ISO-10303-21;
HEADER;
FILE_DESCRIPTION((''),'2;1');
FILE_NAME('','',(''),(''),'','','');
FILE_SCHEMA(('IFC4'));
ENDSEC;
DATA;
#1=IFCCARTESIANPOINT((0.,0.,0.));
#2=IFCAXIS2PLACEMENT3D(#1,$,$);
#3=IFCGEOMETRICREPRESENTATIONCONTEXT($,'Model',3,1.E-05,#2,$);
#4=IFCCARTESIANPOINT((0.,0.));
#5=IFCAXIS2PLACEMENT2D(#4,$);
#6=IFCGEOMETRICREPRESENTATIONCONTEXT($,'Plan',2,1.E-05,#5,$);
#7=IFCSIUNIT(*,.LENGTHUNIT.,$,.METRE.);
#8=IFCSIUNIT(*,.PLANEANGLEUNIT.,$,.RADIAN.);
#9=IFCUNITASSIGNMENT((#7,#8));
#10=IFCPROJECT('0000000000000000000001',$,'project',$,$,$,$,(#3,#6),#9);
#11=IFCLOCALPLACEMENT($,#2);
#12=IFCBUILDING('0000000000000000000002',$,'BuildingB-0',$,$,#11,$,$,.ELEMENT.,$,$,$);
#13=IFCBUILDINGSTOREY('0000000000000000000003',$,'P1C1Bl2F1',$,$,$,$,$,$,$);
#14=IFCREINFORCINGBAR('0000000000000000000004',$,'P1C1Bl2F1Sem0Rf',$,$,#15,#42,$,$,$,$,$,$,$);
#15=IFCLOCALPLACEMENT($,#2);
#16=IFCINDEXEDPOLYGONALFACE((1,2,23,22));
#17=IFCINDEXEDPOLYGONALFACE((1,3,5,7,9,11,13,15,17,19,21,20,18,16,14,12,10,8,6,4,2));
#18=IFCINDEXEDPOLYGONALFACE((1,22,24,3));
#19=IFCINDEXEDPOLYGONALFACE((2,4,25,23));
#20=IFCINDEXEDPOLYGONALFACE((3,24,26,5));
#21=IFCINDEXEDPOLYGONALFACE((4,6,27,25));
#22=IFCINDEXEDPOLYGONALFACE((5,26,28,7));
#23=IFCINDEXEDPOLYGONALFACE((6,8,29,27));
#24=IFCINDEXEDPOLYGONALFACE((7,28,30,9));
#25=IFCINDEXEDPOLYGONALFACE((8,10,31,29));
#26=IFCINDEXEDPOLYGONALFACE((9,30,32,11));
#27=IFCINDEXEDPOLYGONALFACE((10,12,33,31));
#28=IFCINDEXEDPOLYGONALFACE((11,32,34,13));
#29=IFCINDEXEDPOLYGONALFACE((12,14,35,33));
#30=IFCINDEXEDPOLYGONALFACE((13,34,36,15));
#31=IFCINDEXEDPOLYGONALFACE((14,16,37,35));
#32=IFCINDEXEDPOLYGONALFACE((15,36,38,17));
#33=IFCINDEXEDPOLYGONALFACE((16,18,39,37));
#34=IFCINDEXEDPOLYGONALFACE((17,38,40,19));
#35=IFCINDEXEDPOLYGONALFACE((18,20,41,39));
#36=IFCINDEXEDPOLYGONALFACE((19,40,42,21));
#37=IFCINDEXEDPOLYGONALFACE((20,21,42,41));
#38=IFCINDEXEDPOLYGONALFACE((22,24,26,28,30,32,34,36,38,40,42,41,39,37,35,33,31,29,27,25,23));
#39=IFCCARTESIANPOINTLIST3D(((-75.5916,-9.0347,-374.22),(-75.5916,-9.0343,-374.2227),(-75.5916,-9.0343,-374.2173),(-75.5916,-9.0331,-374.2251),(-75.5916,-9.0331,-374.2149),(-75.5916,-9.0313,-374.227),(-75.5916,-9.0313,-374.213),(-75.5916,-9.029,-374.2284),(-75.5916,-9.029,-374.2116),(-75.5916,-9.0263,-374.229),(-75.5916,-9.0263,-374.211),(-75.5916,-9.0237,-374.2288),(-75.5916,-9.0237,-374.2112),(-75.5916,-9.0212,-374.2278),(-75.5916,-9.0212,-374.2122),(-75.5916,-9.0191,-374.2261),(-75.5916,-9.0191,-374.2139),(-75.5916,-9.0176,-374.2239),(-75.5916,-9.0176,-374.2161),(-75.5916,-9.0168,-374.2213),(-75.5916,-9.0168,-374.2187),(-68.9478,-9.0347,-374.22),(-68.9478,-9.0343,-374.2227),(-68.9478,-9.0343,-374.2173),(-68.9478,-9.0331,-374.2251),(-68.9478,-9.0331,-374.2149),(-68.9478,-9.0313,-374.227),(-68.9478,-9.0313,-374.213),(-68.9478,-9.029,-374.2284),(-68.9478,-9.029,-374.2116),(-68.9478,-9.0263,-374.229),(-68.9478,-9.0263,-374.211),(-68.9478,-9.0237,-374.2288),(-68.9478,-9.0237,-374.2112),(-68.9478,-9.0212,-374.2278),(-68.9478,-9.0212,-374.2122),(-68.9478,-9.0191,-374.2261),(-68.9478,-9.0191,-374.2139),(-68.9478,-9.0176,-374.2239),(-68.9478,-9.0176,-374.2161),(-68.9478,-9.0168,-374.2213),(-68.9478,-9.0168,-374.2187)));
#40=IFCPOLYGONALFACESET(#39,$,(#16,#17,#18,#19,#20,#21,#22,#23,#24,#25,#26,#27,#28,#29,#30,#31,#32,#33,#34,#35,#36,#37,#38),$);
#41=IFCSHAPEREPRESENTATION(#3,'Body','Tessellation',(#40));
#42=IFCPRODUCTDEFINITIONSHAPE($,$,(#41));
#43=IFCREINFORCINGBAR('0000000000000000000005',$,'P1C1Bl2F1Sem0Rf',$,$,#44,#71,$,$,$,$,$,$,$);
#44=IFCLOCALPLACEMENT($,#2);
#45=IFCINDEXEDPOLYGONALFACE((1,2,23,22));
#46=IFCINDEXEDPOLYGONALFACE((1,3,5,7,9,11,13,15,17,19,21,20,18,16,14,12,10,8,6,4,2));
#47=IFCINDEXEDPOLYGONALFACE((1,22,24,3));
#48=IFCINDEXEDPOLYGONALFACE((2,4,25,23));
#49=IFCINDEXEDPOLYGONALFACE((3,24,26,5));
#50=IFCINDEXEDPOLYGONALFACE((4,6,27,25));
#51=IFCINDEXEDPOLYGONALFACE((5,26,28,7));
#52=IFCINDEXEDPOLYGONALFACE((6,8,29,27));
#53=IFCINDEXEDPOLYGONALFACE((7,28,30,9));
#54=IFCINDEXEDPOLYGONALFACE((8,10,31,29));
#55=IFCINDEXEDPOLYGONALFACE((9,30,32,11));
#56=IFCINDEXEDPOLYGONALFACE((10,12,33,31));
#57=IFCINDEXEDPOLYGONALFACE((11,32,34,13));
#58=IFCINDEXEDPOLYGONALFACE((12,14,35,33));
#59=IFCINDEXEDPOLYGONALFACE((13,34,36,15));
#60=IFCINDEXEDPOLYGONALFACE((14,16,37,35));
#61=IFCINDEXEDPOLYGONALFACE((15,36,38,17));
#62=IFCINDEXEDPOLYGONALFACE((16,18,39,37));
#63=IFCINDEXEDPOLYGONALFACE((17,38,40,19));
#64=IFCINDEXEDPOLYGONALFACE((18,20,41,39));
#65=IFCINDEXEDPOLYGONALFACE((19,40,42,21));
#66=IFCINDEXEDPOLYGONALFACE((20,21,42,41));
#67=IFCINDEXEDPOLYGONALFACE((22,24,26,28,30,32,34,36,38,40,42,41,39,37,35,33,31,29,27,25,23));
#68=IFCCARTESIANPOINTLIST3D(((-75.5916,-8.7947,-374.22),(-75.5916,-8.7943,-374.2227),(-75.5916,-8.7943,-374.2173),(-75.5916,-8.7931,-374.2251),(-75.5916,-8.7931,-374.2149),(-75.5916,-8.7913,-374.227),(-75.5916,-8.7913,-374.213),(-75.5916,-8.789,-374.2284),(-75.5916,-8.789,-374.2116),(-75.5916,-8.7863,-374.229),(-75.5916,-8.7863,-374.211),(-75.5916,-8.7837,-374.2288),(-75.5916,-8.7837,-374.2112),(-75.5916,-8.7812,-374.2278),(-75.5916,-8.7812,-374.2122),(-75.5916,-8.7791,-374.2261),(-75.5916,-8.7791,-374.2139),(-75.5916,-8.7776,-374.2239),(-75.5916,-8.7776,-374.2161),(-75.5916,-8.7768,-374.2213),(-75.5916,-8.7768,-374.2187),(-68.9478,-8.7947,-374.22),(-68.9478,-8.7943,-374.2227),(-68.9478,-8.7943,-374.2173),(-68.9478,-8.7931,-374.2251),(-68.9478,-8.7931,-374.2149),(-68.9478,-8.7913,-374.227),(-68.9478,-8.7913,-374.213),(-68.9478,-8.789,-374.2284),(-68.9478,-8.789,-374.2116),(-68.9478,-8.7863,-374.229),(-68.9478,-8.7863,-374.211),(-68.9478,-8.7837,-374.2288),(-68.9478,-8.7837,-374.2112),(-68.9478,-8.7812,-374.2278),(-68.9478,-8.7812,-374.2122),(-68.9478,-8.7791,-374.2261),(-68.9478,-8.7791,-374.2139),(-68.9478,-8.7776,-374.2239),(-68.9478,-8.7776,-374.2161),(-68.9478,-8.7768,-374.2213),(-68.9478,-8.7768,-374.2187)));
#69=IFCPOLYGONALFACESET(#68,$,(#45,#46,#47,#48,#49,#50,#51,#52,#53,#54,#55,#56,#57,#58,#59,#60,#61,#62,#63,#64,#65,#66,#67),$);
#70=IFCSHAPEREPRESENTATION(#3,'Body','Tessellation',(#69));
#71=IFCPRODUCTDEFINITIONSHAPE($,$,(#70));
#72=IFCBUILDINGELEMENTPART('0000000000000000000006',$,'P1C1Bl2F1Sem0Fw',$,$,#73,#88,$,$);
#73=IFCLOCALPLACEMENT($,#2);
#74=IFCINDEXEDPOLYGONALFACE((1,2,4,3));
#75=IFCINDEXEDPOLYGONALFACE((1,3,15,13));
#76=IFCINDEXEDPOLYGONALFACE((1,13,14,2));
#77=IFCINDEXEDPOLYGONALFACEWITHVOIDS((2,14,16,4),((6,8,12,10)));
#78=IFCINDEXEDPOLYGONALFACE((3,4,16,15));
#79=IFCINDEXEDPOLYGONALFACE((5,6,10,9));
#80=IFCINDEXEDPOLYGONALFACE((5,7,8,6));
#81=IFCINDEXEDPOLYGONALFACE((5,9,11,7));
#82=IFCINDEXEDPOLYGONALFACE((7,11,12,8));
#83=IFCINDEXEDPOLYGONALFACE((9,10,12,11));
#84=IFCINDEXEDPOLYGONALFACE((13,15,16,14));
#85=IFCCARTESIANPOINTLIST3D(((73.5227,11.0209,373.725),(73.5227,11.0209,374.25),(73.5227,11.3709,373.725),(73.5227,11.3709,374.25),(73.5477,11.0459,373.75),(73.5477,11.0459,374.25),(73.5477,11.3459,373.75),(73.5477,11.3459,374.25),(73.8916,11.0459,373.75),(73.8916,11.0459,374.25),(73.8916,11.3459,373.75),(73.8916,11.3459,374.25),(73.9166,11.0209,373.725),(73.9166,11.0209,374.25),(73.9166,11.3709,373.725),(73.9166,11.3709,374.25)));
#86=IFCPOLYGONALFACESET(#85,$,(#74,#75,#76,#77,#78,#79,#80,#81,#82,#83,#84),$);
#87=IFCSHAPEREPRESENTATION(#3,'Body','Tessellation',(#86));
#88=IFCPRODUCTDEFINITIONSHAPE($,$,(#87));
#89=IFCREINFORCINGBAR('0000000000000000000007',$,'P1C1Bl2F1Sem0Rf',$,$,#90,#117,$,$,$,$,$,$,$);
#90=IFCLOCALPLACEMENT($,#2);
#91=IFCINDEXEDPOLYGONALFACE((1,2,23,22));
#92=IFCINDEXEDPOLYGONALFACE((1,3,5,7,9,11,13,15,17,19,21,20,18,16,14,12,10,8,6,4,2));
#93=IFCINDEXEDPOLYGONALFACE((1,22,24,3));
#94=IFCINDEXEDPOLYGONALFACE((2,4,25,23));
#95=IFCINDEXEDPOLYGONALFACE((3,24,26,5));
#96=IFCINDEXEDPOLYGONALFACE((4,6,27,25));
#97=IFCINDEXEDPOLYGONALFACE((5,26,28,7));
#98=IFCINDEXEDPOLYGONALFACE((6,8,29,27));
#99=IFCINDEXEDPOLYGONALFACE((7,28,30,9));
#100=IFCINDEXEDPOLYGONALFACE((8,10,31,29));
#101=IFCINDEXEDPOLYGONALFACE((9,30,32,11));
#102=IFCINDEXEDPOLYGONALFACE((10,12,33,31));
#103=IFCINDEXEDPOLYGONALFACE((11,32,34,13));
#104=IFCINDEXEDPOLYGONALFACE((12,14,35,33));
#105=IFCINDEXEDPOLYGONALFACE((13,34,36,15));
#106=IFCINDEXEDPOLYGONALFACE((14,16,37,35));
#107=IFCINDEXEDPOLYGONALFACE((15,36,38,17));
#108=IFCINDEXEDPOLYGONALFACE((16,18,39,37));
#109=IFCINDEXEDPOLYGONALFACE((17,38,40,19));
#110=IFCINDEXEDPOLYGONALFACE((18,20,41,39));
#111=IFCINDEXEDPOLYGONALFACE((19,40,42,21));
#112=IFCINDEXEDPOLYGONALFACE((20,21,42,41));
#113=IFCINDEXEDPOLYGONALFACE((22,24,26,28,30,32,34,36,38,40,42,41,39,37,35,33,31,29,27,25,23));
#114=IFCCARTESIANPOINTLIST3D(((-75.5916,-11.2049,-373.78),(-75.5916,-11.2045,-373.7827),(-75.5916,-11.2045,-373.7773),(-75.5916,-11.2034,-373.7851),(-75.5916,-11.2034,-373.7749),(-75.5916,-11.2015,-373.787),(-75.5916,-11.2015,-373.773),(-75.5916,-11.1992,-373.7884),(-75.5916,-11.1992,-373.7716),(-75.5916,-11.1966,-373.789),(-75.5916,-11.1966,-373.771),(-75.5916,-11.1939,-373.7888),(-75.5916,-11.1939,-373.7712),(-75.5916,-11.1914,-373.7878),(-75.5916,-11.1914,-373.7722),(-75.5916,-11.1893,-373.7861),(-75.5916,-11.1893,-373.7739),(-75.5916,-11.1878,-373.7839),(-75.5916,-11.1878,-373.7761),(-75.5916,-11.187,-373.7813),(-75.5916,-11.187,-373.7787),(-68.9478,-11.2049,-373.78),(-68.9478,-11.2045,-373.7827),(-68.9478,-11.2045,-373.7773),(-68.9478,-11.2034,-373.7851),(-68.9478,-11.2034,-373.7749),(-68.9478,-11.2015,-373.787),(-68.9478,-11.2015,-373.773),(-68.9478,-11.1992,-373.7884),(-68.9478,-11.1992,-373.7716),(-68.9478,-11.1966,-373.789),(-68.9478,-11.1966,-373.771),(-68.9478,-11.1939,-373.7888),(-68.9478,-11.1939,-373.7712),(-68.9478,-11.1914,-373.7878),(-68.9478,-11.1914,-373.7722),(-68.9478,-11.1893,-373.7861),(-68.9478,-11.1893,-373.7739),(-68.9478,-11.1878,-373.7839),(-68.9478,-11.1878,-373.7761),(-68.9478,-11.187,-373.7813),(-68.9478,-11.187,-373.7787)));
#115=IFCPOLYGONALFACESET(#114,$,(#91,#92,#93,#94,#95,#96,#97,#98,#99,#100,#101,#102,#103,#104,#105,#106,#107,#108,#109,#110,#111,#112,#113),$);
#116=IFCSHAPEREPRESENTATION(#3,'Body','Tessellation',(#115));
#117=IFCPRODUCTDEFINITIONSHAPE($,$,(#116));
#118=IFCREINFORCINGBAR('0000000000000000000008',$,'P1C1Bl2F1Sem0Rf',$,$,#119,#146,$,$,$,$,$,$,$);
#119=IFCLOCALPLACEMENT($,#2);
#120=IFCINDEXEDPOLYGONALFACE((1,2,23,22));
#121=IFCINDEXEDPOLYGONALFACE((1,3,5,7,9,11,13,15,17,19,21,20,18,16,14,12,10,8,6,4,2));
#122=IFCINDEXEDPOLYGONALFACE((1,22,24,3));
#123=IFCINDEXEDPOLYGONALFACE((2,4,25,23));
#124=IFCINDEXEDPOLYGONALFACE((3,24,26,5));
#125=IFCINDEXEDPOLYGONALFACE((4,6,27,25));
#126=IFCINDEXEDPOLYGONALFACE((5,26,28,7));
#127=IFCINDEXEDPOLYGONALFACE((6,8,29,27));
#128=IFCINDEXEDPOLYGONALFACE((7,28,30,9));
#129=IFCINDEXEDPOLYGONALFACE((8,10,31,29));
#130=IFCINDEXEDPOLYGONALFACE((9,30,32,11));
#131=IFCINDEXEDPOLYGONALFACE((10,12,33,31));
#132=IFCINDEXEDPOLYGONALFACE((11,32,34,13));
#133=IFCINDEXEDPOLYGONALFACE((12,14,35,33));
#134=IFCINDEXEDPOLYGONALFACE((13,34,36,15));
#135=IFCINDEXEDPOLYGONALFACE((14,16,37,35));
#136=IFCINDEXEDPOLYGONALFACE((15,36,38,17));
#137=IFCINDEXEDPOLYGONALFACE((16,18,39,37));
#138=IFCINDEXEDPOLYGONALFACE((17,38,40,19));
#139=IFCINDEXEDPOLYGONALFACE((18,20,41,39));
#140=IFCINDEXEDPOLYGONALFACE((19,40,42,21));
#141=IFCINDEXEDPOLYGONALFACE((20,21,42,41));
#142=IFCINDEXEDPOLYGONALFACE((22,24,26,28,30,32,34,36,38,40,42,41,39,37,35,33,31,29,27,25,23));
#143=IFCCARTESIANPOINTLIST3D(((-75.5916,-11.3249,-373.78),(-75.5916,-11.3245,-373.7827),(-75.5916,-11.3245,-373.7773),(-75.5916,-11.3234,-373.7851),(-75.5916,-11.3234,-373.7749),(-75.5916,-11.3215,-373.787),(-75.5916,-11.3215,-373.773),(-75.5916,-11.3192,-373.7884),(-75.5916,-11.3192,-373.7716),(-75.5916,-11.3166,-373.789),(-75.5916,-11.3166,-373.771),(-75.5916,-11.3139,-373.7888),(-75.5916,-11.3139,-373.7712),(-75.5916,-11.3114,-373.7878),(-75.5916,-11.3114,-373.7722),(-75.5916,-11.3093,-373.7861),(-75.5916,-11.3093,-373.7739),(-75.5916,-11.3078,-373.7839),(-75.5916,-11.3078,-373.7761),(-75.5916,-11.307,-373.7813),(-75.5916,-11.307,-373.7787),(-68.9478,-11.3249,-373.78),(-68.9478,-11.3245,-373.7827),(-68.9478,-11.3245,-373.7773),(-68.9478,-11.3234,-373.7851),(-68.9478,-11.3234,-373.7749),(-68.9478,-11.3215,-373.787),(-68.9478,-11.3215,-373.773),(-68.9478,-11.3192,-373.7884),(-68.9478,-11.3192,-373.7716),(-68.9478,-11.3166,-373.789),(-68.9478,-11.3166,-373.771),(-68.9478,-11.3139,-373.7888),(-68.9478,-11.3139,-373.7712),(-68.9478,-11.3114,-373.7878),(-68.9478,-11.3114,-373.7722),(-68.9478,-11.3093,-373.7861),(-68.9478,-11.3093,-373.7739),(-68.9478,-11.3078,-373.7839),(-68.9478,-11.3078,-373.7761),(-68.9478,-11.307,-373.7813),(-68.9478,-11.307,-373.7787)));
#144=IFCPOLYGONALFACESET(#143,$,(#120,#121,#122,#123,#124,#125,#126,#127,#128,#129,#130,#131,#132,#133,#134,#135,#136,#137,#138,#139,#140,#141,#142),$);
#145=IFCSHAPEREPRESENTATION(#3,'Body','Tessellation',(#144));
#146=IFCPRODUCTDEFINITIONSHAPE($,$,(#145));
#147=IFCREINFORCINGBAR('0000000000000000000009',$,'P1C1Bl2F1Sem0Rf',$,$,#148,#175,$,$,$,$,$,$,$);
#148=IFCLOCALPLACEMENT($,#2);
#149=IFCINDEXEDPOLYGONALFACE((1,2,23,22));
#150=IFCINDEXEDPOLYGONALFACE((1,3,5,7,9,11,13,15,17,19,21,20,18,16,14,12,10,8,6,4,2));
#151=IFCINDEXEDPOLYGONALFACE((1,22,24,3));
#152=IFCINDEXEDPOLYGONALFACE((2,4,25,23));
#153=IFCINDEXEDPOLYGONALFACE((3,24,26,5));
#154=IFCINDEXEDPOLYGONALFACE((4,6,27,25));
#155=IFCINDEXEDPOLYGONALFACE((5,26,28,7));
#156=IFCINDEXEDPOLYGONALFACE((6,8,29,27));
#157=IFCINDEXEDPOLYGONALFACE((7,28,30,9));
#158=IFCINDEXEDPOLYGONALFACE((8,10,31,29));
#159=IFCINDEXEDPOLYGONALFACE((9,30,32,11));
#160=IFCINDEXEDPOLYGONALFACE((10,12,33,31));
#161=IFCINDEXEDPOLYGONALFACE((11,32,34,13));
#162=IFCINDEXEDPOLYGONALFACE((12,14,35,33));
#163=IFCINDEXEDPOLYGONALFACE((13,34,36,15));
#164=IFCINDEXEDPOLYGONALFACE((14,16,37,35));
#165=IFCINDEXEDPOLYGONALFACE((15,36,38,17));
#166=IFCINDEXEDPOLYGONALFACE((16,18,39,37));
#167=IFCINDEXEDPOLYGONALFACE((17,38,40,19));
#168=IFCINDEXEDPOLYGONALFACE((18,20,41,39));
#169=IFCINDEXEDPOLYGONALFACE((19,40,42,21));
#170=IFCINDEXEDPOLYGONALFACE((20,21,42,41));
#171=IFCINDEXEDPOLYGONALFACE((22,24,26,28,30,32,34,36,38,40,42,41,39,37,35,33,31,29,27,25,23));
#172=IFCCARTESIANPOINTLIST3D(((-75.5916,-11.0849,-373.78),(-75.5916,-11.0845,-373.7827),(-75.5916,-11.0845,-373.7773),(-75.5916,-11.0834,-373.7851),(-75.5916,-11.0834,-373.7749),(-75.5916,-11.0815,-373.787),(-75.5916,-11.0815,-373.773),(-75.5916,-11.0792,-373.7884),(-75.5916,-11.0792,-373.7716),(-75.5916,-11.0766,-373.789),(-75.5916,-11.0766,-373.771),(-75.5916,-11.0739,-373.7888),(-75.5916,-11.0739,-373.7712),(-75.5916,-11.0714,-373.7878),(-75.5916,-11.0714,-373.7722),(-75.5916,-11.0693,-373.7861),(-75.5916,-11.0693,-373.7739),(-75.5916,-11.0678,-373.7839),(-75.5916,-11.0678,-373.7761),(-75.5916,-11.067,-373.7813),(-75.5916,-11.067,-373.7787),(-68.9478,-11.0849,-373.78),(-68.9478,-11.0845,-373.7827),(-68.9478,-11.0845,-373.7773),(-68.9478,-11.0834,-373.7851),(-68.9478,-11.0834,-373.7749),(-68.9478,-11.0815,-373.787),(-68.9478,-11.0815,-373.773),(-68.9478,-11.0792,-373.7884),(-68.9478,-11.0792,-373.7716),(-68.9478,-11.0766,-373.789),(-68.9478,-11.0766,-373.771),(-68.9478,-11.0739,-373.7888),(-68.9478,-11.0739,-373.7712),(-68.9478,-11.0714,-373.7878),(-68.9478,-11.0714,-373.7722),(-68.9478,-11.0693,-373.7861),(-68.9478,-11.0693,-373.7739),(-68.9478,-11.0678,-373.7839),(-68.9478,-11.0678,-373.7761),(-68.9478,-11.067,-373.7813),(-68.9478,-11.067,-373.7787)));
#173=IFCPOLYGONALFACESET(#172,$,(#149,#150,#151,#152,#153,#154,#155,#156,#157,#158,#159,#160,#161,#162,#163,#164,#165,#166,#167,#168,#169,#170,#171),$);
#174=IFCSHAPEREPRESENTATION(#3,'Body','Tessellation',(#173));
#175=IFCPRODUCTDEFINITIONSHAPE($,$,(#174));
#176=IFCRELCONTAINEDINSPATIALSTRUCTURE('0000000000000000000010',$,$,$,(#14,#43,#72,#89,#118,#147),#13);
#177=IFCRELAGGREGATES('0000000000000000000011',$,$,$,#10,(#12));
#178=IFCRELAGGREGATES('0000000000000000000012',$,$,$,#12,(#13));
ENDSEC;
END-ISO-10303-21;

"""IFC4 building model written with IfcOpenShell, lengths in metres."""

from ifc_helpers import new_model, entity, si_unit, origin, origin_2d, place, context, project, spatial, polyline, outline, extrude, element, save


model = new_model("IFC4")

# Units and contexts
model_context = context("Model", 3, precision=1e-05, world=origin())
plan_context = context("Plan", 2, precision=1e-05, world=origin_2d())
ifc_project = project(units=[si_unit("LENGTHUNIT", "METRE"), si_unit("PLANEANGLEUNIT", "RADIAN")], contexts=[model_context, plan_context])

# Building, storey
building_placement = place(None, origin())
building = spatial("IfcBuilding", under=ifc_project, at=building_placement, Name="BuildingB-0", CompositionType="ELEMENT")
storey = spatial("IfcBuildingStorey", under=building, Name="P1C1Bl2F1")

# Reinforcing bars
element("IfcReinforcingBar", 1, inside=storey, Name="P1C1Bl2F1Sem0Rf", context=model_context, shape_type="SweptSolid", body=[
    entity("IfcSurfaceCurveSweptAreaSolid", entity("IfcCircleProfileDef", "AREA", None, None, 0.009), None, entity("IfcPolyline", [entity("IfcCartesianPoint", [75.5916, 9.0257, 374.22]), entity("IfcCartesianPoint", [68.9478, 9.0257, 374.22])]), None, None, entity("IfcPlane", entity("IfcAxis2Placement3D", entity("IfcCartesianPoint", [75.5916, 9.0257, 374.22]), entity("IfcDirection", [0.0, 0.0, 1.0]), entity("IfcDirection", [1.0, 0.0, 0.0])))),
])
element("IfcReinforcingBar", 2, inside=storey, Name="P1C1Bl2F1Sem0Rf", context=model_context, shape_type="SweptSolid", body=[
    entity("IfcSurfaceCurveSweptAreaSolid", entity("IfcCircleProfileDef", "AREA", None, None, 0.009), None, entity("IfcPolyline", [entity("IfcCartesianPoint", [75.5916, 8.7857, 374.22]), entity("IfcCartesianPoint", [68.9478, 8.7857, 374.22])]), None, None, entity("IfcPlane", entity("IfcAxis2Placement3D", entity("IfcCartesianPoint", [75.5916, 8.7857, 374.22]), entity("IfcDirection", [0.0, 0.0, 1.0]), entity("IfcDirection", [1.0, 0.0, 0.0])))),
])

# Building element part, opening
building_element_part_1 = element("IfcBuildingElementPart", 3, inside=storey, Name="P1C1Bl2F1Sem0Fw", context=model_context, shape_type="SweptSolid", body=[
    extrude(outline(polyline([(73.9166, 11.0209, 373.725), (73.5227, 11.0209, 373.725), (73.5227, 11.3709, 373.725), (73.9166, 11.3709, 373.725), (73.9166, 11.0209, 373.725)])), None, (0.0, 0.0, 1.0), 0.525),
])
element("IfcOpeningElement", 4, inside=storey, cuts=building_element_part_1, context=model_context, shape_type="SweptSolid", body=[
    extrude(outline(polyline([(73.8916, 11.0459, 373.75), (73.5477, 11.0459, 373.75), (73.5477, 11.3459, 373.75), (73.8916, 11.3459, 373.75), (73.8916, 11.0459, 373.75)])), None, (0.0, 0.0, 1.0), 0.5),
])

# Reinforcing bars
element("IfcReinforcingBar", 5, inside=storey, Name="P1C1Bl2F1Sem0Rf", context=model_context, shape_type="SweptSolid", body=[
    entity("IfcSurfaceCurveSweptAreaSolid", entity("IfcCircleProfileDef", "AREA", None, None, 0.009), None, entity("IfcPolyline", [entity("IfcCartesianPoint", [75.5916, 11.1959, 373.78]), entity("IfcCartesianPoint", [68.9478, 11.1959, 373.78])]), None, None, entity("IfcPlane", entity("IfcAxis2Placement3D", entity("IfcCartesianPoint", [75.5916, 11.1959, 373.78]), entity("IfcDirection", [0.0, 0.0, 1.0]), entity("IfcDirection", [1.0, 0.0, 0.0])))),
])
element("IfcReinforcingBar", 6, inside=storey, Name="P1C1Bl2F1Sem0Rf", context=model_context, shape_type="SweptSolid", body=[
    entity("IfcSurfaceCurveSweptAreaSolid", entity("IfcCircleProfileDef", "AREA", None, None, 0.009), None, entity("IfcPolyline", [entity("IfcCartesianPoint", [75.5916, 11.3159, 373.78]), entity("IfcCartesianPoint", [68.9478, 11.3159, 373.78])]), None, None, entity("IfcPlane", entity("IfcAxis2Placement3D", entity("IfcCartesianPoint", [75.5916, 11.3159, 373.78]), entity("IfcDirection", [0.0, 0.0, 1.0]), entity("IfcDirection", [1.0, 0.0, 0.0])))),
])
element("IfcReinforcingBar", 7, inside=storey, Name="P1C1Bl2F1Sem0Rf", context=model_context, shape_type="SweptSolid", body=[
    entity("IfcSurfaceCurveSweptAreaSolid", entity("IfcCircleProfileDef", "AREA", None, None, 0.009), None, entity("IfcPolyline", [entity("IfcCartesianPoint", [75.5916, 11.0759, 373.78]), entity("IfcCartesianPoint", [68.9478, 11.0759, 373.78])]), None, None, entity("IfcPlane", entity("IfcAxis2Placement3D", entity("IfcCartesianPoint", [75.5916, 11.0759, 373.78]), entity("IfcDirection", [0.0, 0.0, 1.0]), entity("IfcDirection", [1.0, 0.0, 0.0])))),
])

save(model, "model.ifc")
